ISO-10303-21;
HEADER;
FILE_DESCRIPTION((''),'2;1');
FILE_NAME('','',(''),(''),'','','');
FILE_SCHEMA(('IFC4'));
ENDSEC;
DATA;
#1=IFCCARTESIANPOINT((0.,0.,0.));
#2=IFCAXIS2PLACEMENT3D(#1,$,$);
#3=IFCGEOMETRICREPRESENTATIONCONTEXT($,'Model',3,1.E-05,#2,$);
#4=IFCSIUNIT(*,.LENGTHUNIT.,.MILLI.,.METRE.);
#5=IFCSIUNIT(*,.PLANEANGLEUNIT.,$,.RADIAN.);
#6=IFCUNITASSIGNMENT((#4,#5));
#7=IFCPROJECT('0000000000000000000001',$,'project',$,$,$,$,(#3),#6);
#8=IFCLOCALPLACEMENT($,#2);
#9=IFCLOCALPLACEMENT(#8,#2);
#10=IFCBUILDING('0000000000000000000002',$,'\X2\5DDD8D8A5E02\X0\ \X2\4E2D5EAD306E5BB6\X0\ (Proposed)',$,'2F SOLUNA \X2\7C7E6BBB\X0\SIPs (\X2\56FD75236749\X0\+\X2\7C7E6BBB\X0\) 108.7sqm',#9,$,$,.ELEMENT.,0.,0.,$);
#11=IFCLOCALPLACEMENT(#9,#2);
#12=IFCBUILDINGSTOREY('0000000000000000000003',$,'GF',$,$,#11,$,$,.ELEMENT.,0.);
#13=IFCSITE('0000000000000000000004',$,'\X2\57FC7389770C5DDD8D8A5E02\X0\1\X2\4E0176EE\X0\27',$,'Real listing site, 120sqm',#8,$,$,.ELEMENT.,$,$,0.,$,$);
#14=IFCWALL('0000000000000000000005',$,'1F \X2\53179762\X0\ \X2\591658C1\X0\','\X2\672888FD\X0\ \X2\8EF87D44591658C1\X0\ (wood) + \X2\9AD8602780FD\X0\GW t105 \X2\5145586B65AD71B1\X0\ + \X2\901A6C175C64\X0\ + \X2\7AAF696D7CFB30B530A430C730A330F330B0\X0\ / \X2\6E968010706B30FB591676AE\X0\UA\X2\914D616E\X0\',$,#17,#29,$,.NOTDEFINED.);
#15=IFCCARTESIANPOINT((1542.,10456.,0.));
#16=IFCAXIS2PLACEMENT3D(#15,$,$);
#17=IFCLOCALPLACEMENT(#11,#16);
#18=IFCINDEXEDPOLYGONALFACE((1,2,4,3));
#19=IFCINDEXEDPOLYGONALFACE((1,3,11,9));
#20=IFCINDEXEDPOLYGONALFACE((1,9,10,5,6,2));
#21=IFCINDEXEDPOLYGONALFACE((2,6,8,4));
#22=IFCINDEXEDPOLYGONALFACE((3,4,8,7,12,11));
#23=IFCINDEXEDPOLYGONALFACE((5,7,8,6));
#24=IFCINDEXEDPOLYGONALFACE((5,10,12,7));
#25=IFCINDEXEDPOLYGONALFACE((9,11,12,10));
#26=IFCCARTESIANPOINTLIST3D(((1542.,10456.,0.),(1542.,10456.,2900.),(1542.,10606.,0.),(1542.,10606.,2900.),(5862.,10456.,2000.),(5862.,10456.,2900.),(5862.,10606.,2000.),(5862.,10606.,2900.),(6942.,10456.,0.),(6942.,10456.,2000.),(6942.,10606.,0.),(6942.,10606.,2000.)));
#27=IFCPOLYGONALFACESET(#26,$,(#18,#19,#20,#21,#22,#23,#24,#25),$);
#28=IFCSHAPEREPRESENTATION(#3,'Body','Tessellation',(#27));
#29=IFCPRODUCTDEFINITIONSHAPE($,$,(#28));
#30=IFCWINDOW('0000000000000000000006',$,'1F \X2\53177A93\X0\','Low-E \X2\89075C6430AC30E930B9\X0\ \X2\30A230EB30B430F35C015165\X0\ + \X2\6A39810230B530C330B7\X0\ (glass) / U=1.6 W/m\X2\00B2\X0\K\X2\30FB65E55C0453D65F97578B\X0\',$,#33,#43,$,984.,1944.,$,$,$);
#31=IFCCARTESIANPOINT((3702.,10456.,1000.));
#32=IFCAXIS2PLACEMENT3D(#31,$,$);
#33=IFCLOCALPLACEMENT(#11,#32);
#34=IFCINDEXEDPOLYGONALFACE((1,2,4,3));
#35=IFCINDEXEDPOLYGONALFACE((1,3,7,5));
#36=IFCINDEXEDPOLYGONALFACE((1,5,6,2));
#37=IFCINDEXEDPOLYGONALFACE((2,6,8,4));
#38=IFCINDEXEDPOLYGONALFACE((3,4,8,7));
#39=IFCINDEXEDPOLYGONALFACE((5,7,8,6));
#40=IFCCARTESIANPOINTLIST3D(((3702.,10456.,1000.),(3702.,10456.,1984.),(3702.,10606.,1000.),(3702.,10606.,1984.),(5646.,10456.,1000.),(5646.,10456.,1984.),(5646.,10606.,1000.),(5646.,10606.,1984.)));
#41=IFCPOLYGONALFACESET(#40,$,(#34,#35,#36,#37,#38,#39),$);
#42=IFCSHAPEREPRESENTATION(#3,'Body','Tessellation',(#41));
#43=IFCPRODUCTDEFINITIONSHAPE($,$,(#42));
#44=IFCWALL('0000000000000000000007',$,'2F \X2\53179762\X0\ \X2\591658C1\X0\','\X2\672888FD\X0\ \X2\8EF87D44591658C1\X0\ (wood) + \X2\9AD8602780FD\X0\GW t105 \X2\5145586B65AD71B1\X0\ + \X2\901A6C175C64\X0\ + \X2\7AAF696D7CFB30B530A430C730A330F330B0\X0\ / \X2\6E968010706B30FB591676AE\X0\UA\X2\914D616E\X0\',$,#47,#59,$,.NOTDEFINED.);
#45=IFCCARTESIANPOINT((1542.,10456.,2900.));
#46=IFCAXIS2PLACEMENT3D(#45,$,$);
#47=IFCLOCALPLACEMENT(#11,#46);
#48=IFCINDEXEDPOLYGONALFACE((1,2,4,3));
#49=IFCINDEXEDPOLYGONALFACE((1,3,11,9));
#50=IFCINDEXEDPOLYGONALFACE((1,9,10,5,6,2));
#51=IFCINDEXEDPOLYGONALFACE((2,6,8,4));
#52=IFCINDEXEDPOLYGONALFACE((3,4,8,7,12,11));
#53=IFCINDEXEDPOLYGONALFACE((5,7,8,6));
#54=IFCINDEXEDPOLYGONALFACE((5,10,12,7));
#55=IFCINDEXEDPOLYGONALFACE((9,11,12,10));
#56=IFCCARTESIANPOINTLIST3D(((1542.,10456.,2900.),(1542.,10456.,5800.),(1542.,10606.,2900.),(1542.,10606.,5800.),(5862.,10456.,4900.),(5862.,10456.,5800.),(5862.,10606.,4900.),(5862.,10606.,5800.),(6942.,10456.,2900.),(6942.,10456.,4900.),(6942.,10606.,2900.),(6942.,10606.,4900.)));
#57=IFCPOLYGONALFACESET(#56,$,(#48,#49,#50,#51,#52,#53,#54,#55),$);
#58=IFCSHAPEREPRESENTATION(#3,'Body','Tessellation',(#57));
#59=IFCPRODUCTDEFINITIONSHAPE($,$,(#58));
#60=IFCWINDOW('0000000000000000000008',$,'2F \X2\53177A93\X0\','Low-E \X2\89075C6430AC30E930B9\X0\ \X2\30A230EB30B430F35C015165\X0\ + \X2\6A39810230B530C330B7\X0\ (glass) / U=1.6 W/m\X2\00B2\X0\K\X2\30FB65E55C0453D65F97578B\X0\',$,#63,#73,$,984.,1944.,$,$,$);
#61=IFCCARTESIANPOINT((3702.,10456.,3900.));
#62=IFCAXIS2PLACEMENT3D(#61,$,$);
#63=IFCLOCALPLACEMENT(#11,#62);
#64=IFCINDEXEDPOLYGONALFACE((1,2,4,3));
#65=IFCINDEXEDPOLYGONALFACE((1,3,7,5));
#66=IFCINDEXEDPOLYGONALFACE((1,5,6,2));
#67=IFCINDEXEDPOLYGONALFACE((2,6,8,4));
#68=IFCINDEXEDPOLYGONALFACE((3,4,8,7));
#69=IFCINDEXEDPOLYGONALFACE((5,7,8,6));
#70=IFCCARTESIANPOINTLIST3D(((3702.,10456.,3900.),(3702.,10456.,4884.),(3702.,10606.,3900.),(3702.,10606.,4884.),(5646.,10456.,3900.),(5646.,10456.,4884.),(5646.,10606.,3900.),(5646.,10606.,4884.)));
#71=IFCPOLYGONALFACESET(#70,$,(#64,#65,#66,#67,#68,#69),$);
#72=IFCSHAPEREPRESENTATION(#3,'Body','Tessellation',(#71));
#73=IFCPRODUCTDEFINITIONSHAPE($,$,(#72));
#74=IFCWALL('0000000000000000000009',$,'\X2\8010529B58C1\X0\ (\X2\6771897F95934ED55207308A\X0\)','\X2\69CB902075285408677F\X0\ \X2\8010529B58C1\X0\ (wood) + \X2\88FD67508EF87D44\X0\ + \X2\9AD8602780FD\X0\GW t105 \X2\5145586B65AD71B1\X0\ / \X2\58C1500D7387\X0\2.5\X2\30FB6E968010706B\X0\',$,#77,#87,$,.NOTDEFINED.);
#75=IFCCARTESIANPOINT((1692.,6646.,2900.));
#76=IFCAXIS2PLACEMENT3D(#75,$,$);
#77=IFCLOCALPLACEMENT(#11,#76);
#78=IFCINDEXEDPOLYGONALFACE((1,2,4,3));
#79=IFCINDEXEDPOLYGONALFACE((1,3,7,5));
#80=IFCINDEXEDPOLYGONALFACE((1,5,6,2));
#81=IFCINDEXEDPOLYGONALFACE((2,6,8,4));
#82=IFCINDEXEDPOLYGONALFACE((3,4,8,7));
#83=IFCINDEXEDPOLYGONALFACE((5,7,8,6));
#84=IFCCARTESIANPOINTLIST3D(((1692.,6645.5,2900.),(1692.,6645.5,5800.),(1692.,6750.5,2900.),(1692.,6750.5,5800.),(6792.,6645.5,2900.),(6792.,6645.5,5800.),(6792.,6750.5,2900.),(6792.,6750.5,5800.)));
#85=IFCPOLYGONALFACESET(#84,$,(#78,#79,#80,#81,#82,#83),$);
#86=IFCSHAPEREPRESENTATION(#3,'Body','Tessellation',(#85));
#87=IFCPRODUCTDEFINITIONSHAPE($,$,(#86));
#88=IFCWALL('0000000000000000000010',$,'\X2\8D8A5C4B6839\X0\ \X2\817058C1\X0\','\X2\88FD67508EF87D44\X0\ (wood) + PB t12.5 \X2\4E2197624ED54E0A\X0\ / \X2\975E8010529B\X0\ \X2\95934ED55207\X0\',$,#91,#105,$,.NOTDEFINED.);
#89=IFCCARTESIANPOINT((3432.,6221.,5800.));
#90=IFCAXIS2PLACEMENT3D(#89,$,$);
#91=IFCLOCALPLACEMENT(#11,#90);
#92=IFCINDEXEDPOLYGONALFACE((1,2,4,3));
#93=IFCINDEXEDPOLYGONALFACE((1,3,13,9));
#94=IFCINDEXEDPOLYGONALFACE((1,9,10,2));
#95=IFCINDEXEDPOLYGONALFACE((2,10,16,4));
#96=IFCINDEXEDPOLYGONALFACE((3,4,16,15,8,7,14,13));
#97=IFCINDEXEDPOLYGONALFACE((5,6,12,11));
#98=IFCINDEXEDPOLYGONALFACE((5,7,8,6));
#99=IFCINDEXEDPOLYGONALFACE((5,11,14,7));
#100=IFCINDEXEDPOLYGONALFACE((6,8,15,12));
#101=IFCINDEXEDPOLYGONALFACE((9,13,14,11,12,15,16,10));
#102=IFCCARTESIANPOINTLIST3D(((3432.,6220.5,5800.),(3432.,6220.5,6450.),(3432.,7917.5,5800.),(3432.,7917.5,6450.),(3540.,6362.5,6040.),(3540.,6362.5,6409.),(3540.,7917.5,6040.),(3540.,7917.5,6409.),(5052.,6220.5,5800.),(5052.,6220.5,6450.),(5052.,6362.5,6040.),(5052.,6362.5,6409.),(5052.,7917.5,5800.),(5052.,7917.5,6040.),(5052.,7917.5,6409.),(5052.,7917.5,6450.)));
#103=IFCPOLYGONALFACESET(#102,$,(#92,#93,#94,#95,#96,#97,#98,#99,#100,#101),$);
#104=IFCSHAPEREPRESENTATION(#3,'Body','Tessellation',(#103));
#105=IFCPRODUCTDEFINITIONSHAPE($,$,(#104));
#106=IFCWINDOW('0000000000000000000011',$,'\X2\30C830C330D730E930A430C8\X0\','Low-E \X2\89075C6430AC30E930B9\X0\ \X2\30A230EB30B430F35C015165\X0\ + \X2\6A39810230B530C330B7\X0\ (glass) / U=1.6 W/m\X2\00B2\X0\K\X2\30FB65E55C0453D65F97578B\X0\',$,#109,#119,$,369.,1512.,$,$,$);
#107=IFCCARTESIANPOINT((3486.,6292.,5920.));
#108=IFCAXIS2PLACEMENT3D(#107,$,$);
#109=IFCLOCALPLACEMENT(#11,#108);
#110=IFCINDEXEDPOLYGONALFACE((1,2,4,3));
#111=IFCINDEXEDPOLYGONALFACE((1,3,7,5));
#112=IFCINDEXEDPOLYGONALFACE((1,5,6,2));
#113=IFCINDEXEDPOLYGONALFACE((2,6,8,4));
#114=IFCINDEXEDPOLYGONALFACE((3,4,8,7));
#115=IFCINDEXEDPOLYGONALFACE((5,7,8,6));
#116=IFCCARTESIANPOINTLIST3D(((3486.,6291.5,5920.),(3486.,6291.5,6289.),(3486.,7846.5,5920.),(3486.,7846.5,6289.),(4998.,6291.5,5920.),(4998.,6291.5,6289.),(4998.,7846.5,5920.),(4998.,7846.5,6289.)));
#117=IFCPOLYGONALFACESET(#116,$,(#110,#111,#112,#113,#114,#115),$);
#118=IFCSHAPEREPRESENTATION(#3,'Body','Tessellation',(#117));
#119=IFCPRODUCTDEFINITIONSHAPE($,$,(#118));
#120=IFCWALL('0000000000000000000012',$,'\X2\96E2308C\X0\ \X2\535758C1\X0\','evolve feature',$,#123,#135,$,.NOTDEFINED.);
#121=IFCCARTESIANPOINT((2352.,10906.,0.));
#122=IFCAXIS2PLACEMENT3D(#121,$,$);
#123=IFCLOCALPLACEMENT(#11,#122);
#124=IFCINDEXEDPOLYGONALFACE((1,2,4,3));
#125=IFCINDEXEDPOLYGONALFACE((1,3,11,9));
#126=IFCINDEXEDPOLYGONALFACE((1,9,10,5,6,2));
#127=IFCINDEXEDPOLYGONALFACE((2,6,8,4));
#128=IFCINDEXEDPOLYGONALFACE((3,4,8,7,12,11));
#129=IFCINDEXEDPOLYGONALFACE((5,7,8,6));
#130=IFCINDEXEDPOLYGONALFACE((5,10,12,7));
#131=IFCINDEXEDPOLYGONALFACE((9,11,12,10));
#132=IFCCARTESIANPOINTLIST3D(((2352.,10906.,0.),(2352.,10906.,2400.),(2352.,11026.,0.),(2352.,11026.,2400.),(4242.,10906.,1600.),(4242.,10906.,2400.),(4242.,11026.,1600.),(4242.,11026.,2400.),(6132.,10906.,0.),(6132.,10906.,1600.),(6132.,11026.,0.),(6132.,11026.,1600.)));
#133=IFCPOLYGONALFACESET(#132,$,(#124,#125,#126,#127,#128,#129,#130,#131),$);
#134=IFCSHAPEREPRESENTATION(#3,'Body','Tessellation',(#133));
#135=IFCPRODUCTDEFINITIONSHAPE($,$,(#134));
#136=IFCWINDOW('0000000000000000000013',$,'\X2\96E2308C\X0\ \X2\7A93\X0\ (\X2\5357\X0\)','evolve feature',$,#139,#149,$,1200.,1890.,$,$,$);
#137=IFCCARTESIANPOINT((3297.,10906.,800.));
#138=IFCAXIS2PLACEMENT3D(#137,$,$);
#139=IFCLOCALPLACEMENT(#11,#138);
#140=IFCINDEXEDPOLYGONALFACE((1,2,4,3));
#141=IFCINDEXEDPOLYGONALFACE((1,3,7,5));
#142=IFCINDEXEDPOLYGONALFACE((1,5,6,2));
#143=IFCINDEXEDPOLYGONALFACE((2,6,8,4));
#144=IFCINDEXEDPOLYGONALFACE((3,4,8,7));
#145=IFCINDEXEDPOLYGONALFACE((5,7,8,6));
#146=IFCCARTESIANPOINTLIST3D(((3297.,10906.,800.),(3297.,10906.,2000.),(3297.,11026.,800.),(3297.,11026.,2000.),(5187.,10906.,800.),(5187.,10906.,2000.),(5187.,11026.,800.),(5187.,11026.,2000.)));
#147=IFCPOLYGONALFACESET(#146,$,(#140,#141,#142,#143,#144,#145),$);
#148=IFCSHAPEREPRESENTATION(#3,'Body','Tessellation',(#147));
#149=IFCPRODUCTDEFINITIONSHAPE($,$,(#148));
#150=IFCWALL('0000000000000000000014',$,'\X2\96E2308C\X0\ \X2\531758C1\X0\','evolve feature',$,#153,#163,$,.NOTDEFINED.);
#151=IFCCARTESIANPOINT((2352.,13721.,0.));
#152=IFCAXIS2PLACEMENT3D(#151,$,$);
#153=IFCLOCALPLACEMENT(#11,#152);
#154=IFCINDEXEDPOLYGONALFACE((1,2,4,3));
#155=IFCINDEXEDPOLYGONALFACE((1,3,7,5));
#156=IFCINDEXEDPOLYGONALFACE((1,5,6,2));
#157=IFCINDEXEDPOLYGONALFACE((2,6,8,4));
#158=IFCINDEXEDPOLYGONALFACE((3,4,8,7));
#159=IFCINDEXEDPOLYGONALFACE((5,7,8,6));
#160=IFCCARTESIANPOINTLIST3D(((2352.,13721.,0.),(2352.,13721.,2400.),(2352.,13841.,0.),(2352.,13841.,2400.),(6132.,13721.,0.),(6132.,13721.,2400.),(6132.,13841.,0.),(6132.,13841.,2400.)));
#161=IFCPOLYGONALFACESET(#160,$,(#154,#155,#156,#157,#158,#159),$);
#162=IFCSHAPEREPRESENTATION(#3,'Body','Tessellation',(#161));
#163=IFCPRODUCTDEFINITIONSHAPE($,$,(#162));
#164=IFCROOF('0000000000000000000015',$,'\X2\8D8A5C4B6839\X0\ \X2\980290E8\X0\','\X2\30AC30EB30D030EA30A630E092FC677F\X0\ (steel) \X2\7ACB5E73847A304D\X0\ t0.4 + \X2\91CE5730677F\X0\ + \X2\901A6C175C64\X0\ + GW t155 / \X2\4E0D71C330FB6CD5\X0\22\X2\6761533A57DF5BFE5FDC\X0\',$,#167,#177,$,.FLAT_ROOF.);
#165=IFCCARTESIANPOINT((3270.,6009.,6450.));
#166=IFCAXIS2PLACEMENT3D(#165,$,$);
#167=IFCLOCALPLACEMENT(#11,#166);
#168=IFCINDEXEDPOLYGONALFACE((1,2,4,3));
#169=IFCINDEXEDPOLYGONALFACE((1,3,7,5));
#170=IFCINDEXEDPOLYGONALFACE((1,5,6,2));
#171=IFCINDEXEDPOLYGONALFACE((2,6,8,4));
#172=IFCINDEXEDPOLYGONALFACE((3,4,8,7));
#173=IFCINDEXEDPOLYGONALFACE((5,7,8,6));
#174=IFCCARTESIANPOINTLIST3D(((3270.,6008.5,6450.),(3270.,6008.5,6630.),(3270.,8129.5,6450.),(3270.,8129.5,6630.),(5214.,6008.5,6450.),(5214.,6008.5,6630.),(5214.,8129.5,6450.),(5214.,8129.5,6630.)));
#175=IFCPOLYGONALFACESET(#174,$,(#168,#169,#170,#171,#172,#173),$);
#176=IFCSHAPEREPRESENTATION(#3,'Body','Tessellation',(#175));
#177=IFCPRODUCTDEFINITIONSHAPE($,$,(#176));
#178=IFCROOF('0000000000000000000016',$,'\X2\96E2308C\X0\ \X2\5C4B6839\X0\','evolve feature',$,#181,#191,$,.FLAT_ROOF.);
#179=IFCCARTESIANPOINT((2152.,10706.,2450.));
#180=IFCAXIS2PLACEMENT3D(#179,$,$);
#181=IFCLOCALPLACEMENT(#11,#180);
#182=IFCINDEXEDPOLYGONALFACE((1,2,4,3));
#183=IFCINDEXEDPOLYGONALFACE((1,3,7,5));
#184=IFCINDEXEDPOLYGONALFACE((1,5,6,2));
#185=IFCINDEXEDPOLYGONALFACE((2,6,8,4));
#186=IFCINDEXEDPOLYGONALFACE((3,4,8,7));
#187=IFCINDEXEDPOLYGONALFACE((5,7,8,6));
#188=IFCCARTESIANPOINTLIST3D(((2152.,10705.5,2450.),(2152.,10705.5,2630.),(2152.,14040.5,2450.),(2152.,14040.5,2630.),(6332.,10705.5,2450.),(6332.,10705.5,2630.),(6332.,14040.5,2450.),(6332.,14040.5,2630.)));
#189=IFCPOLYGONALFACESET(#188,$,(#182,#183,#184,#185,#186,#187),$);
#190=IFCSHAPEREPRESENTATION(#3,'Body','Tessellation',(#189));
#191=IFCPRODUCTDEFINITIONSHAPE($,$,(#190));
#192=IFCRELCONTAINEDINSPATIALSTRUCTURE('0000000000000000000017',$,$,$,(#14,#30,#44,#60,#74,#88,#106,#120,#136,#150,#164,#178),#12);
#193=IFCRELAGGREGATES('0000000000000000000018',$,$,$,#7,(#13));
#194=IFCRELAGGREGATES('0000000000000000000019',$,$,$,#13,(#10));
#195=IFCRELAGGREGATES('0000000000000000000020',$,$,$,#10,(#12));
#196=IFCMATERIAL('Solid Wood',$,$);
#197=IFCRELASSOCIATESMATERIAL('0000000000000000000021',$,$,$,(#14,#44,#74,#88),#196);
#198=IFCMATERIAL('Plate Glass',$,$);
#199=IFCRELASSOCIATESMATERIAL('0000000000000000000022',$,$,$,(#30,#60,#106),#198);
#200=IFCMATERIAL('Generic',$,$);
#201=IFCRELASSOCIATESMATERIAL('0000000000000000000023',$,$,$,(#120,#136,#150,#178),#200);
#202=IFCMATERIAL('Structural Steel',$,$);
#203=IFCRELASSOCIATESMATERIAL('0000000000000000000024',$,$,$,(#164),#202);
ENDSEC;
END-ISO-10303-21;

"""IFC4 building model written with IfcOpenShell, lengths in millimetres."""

from ifc_helpers import new_model, si_unit, frame, frame_2d, origin, place, context, project, spatial, rectangle, extrude, material, element, fill, save


model = new_model("IFC4")

# Units and contexts
model_context = context("Model", 3, precision=1e-05, world=origin())
ifc_project = project(units=[si_unit("LENGTHUNIT", "METRE", prefix="MILLI"), si_unit("PLANEANGLEUNIT", "RADIAN")], contexts=[model_context])

# Site, building, storey
site_placement = place(None, origin())
site = spatial("IfcSite", under=ifc_project, at=site_placement, Name="埼玉県川越市1丁目27", ObjectType="Real listing site, 120sqm", CompositionType="ELEMENT", RefElevation=0.0)
building_placement = place(site_placement, origin())
building = spatial("IfcBuilding", under=site, at=building_placement, Name="川越市 中庭の家 (Proposed)", ObjectType="2F SOLUNA 籾殻SIPs (国産杉+籾殻) 108.7sqm", CompositionType="ELEMENT", ElevationOfRefHeight=0.0, ElevationOfTerrain=0.0)
storey_placement = place(building_placement, origin())
storey = spatial("IfcBuildingStorey", under=building, at=storey_placement, Name="GF", CompositionType="ELEMENT", Elevation=0.0)

# Shared definitions
ifc_material_1 = material(Name="Generic")

# Wall, opening, window
ifc_material_2 = material(Name="Solid Wood")
wall_1_placement = place(storey_placement, frame((1542.0, 10456.0, 0.0)))
wall_1 = element("IfcWall", 1, at=wall_1_placement, inside=storey, material=ifc_material_2, Name="1F 北面 外壁", Description="木製 軸組外壁 (wood) + 高性能GW t105 充填断熱 + 通気層 + 窯業系サイディング / 準耐火・外皮UA配慮", PredefinedType="NOTDEFINED", context=model_context, shape_type="SweptSolid", body=[
    extrude(rectangle(XDim=5400.0, YDim=150.0, at=frame_2d((2700.0, 75.0))), frame((1542.0, 10456.0, 0.0)), (0.0, 0.0, 1.0), 2900.0),
])
opening_1_placement = place(storey_placement, frame((3702.0, 10456.0, 1000.0)))
opening_1 = element("IfcOpeningElement", 2, at=opening_1_placement, cuts=wall_1, PredefinedType="NOTDEFINED", context=model_context, shape_type="SweptSolid", body=[
    extrude(rectangle(XDim=1944.0, YDim=150.0, at=frame_2d((972.0, 75.0))), frame((3702.0, 10456.0, 1000.0)), (0.0, 0.0, 1.0), 984.0),
])
ifc_material_3 = material(Name="Plate Glass")
window_1_placement = place(storey_placement, frame((3702.0, 10456.0, 1000.0)))
window_1 = element("IfcWindow", 3, at=window_1_placement, inside=storey, material=ifc_material_3, Name="1F 北窓", Description="Low-E 複層ガラス アルゴン封入 + 樹脂サッシ (glass) / U=1.6 W/m²K・日射取得型", OverallHeight=984.0, OverallWidth=1944.0, context=model_context, shape_type="SweptSolid", body=[
    extrude(rectangle(XDim=1944.0, YDim=150.0, at=frame_2d((972.0, 75.0))), frame((3702.0, 10456.0, 1000.0)), (0.0, 0.0, 1.0), 984.0),
])
fill(opening_1, window_1)

# Wall, opening, window
wall_2_placement = place(storey_placement, frame((1542.0, 10456.0, 2900.0)))
wall_2 = element("IfcWall", 4, at=wall_2_placement, inside=storey, material=ifc_material_2, Name="2F 北面 外壁", Description="木製 軸組外壁 (wood) + 高性能GW t105 充填断熱 + 通気層 + 窯業系サイディング / 準耐火・外皮UA配慮", PredefinedType="NOTDEFINED", context=model_context, shape_type="SweptSolid", body=[
    extrude(rectangle(XDim=5400.0, YDim=150.0, at=frame_2d((2700.0, 75.0))), frame((1542.0, 10456.0, 2900.0)), (0.0, 0.0, 1.0), 2900.0),
])
opening_2_placement = place(storey_placement, frame((3702.0, 10456.0, 3900.0)))
opening_2 = element("IfcOpeningElement", 5, at=opening_2_placement, cuts=wall_2, PredefinedType="NOTDEFINED", context=model_context, shape_type="SweptSolid", body=[
    extrude(rectangle(XDim=1944.0, YDim=150.0, at=frame_2d((972.0, 75.0))), frame((3702.0, 10456.0, 3900.0)), (0.0, 0.0, 1.0), 984.0),
])
window_2_placement = place(storey_placement, frame((3702.0, 10456.0, 3900.0)))
window_2 = element("IfcWindow", 6, at=window_2_placement, inside=storey, material=ifc_material_3, Name="2F 北窓", Description="Low-E 複層ガラス アルゴン封入 + 樹脂サッシ (glass) / U=1.6 W/m²K・日射取得型", OverallHeight=984.0, OverallWidth=1944.0, context=model_context, shape_type="SweptSolid", body=[
    extrude(rectangle(XDim=1944.0, YDim=150.0, at=frame_2d((972.0, 75.0))), frame((3702.0, 10456.0, 3900.0)), (0.0, 0.0, 1.0), 984.0),
])
fill(opening_2, window_2)

# Wall
wall_3_placement = place(storey_placement, frame((1692.0, 6646.0, 2900.0)))
element("IfcWall", 7, at=wall_3_placement, inside=storey, material=ifc_material_2, Name="耐力壁 (東西間仕切り)", Description="構造用合板 耐力壁 (wood) + 製材軸組 + 高性能GW t105 充填断熱 / 壁倍率2.5・準耐火", PredefinedType="NOTDEFINED", context=model_context, shape_type="SweptSolid", body=[
    extrude(rectangle(XDim=5100.0, YDim=105.0, at=frame_2d((2550.0, 52.0))), frame((1692.0, 6646.0, 2900.0)), (0.0, 0.0, 1.0), 2900.0),
])

# Walls, openings, windows
wall_4_placement = place(storey_placement, frame((3432.0, 6221.0, 5800.0)))
wall_4 = element("IfcWall", 8, at=wall_4_placement, inside=storey, material=ifc_material_2, Name="越屋根 腰壁", Description="製材軸組 (wood) + PB t12.5 両面仕上 / 非耐力 間仕切", PredefinedType="NOTDEFINED", context=model_context, shape_type="SweptSolid", body=[
    extrude(rectangle(XDim=1620.0, YDim=1697.0, at=frame_2d((810.0, 848.0))), frame((3432.0, 6221.0, 5800.0)), (0.0, 0.0, 1.0), 650.0),
])
opening_3_placement = place(storey_placement, frame((3486.0, 6292.0, 5920.0)))
opening_3 = element("IfcOpeningElement", 9, at=opening_3_placement, cuts=wall_4, PredefinedType="NOTDEFINED", context=model_context, shape_type="SweptSolid", body=[
    extrude(rectangle(XDim=1512.0, YDim=1555.0, at=frame_2d((756.0, 777.0))), frame((3486.0, 6292.0, 5920.0)), (0.0, 0.0, 1.0), 369.0),
])
window_3_placement = place(storey_placement, frame((3486.0, 6292.0, 5920.0)))
window_3 = element("IfcWindow", 10, at=window_3_placement, inside=storey, material=ifc_material_3, Name="トップライト", Description="Low-E 複層ガラス アルゴン封入 + 樹脂サッシ (glass) / U=1.6 W/m²K・日射取得型", OverallHeight=369.0, OverallWidth=1512.0, context=model_context, shape_type="SweptSolid", body=[
    extrude(rectangle(XDim=1512.0, YDim=1555.0, at=frame_2d((756.0, 777.0))), frame((3486.0, 6292.0, 5920.0)), (0.0, 0.0, 1.0), 369.0),
])
fill(opening_3, window_3)
wall_5_placement = place(storey_placement, frame((2352.0, 10906.0, 0.0)))
wall_5 = element("IfcWall", 11, at=wall_5_placement, inside=storey, material=ifc_material_1, Name="離れ 南壁", Description="evolve feature", PredefinedType="NOTDEFINED", context=model_context, shape_type="SweptSolid", body=[
    extrude(rectangle(XDim=3780.0, YDim=120.0, at=frame_2d((1890.0, 60.0))), frame((2352.0, 10906.0, 0.0)), (0.0, 0.0, 1.0), 2400.0),
])
opening_4_placement = place(storey_placement, frame((3297.0, 10906.0, 800.0)))
opening_4 = element("IfcOpeningElement", 12, at=opening_4_placement, cuts=wall_5, PredefinedType="NOTDEFINED", context=model_context, shape_type="SweptSolid", body=[
    extrude(rectangle(XDim=1890.0, YDim=120.0, at=frame_2d((945.0, 60.0))), frame((3297.0, 10906.0, 800.0)), (0.0, 0.0, 1.0), 1200.0),
])
window_4_placement = place(storey_placement, frame((3297.0, 10906.0, 800.0)))
window_4 = element("IfcWindow", 13, at=window_4_placement, inside=storey, material=ifc_material_1, Name="離れ 窓 (南)", Description="evolve feature", OverallHeight=1200.0, OverallWidth=1890.0, context=model_context, shape_type="SweptSolid", body=[
    extrude(rectangle(XDim=1890.0, YDim=120.0, at=frame_2d((945.0, 60.0))), frame((3297.0, 10906.0, 800.0)), (0.0, 0.0, 1.0), 1200.0),
])
fill(opening_4, window_4)

# Wall
wall_6_placement = place(storey_placement, frame((2352.0, 13721.0, 0.0)))
element("IfcWall", 14, at=wall_6_placement, inside=storey, material=ifc_material_1, Name="離れ 北壁", Description="evolve feature", PredefinedType="NOTDEFINED", context=model_context, shape_type="SweptSolid", body=[
    extrude(rectangle(XDim=3780.0, YDim=120.0, at=frame_2d((1890.0, 60.0))), frame((2352.0, 13721.0, 0.0)), (0.0, 0.0, 1.0), 2400.0),
])

# Roofs
ifc_material_4 = material(Name="Structural Steel")
roof_1_placement = place(storey_placement, frame((3270.0, 6009.0, 6450.0)))
element("IfcRoof", 15, at=roof_1_placement, inside=storey, material=ifc_material_4, Name="越屋根 頂部", Description="ガルバリウム鋼板 (steel) 立平葺き t0.4 + 野地板 + 通気層 + GW t155 / 不燃・法22条区域対応", PredefinedType="FLAT_ROOF", context=model_context, shape_type="SweptSolid", body=[
    extrude(rectangle(XDim=1944.0, YDim=2121.0, at=frame_2d((972.0, 1060.0))), frame((3270.0, 6009.0, 6450.0)), (0.0, 0.0, 1.0), 180.0),
])
roof_2_placement = place(storey_placement, frame((2152.0, 10706.0, 2450.0)))
element("IfcRoof", 16, at=roof_2_placement, inside=storey, material=ifc_material_1, Name="離れ 屋根", Description="evolve feature", PredefinedType="FLAT_ROOF", context=model_context, shape_type="SweptSolid", body=[
    extrude(rectangle(XDim=4180.0, YDim=3335.0, at=frame_2d((2090.0, 1667.0))), frame((2152.0, 10706.0, 2450.0)), (0.0, 0.0, 1.0), 180.0),
])

save(model, "model.ifc")
